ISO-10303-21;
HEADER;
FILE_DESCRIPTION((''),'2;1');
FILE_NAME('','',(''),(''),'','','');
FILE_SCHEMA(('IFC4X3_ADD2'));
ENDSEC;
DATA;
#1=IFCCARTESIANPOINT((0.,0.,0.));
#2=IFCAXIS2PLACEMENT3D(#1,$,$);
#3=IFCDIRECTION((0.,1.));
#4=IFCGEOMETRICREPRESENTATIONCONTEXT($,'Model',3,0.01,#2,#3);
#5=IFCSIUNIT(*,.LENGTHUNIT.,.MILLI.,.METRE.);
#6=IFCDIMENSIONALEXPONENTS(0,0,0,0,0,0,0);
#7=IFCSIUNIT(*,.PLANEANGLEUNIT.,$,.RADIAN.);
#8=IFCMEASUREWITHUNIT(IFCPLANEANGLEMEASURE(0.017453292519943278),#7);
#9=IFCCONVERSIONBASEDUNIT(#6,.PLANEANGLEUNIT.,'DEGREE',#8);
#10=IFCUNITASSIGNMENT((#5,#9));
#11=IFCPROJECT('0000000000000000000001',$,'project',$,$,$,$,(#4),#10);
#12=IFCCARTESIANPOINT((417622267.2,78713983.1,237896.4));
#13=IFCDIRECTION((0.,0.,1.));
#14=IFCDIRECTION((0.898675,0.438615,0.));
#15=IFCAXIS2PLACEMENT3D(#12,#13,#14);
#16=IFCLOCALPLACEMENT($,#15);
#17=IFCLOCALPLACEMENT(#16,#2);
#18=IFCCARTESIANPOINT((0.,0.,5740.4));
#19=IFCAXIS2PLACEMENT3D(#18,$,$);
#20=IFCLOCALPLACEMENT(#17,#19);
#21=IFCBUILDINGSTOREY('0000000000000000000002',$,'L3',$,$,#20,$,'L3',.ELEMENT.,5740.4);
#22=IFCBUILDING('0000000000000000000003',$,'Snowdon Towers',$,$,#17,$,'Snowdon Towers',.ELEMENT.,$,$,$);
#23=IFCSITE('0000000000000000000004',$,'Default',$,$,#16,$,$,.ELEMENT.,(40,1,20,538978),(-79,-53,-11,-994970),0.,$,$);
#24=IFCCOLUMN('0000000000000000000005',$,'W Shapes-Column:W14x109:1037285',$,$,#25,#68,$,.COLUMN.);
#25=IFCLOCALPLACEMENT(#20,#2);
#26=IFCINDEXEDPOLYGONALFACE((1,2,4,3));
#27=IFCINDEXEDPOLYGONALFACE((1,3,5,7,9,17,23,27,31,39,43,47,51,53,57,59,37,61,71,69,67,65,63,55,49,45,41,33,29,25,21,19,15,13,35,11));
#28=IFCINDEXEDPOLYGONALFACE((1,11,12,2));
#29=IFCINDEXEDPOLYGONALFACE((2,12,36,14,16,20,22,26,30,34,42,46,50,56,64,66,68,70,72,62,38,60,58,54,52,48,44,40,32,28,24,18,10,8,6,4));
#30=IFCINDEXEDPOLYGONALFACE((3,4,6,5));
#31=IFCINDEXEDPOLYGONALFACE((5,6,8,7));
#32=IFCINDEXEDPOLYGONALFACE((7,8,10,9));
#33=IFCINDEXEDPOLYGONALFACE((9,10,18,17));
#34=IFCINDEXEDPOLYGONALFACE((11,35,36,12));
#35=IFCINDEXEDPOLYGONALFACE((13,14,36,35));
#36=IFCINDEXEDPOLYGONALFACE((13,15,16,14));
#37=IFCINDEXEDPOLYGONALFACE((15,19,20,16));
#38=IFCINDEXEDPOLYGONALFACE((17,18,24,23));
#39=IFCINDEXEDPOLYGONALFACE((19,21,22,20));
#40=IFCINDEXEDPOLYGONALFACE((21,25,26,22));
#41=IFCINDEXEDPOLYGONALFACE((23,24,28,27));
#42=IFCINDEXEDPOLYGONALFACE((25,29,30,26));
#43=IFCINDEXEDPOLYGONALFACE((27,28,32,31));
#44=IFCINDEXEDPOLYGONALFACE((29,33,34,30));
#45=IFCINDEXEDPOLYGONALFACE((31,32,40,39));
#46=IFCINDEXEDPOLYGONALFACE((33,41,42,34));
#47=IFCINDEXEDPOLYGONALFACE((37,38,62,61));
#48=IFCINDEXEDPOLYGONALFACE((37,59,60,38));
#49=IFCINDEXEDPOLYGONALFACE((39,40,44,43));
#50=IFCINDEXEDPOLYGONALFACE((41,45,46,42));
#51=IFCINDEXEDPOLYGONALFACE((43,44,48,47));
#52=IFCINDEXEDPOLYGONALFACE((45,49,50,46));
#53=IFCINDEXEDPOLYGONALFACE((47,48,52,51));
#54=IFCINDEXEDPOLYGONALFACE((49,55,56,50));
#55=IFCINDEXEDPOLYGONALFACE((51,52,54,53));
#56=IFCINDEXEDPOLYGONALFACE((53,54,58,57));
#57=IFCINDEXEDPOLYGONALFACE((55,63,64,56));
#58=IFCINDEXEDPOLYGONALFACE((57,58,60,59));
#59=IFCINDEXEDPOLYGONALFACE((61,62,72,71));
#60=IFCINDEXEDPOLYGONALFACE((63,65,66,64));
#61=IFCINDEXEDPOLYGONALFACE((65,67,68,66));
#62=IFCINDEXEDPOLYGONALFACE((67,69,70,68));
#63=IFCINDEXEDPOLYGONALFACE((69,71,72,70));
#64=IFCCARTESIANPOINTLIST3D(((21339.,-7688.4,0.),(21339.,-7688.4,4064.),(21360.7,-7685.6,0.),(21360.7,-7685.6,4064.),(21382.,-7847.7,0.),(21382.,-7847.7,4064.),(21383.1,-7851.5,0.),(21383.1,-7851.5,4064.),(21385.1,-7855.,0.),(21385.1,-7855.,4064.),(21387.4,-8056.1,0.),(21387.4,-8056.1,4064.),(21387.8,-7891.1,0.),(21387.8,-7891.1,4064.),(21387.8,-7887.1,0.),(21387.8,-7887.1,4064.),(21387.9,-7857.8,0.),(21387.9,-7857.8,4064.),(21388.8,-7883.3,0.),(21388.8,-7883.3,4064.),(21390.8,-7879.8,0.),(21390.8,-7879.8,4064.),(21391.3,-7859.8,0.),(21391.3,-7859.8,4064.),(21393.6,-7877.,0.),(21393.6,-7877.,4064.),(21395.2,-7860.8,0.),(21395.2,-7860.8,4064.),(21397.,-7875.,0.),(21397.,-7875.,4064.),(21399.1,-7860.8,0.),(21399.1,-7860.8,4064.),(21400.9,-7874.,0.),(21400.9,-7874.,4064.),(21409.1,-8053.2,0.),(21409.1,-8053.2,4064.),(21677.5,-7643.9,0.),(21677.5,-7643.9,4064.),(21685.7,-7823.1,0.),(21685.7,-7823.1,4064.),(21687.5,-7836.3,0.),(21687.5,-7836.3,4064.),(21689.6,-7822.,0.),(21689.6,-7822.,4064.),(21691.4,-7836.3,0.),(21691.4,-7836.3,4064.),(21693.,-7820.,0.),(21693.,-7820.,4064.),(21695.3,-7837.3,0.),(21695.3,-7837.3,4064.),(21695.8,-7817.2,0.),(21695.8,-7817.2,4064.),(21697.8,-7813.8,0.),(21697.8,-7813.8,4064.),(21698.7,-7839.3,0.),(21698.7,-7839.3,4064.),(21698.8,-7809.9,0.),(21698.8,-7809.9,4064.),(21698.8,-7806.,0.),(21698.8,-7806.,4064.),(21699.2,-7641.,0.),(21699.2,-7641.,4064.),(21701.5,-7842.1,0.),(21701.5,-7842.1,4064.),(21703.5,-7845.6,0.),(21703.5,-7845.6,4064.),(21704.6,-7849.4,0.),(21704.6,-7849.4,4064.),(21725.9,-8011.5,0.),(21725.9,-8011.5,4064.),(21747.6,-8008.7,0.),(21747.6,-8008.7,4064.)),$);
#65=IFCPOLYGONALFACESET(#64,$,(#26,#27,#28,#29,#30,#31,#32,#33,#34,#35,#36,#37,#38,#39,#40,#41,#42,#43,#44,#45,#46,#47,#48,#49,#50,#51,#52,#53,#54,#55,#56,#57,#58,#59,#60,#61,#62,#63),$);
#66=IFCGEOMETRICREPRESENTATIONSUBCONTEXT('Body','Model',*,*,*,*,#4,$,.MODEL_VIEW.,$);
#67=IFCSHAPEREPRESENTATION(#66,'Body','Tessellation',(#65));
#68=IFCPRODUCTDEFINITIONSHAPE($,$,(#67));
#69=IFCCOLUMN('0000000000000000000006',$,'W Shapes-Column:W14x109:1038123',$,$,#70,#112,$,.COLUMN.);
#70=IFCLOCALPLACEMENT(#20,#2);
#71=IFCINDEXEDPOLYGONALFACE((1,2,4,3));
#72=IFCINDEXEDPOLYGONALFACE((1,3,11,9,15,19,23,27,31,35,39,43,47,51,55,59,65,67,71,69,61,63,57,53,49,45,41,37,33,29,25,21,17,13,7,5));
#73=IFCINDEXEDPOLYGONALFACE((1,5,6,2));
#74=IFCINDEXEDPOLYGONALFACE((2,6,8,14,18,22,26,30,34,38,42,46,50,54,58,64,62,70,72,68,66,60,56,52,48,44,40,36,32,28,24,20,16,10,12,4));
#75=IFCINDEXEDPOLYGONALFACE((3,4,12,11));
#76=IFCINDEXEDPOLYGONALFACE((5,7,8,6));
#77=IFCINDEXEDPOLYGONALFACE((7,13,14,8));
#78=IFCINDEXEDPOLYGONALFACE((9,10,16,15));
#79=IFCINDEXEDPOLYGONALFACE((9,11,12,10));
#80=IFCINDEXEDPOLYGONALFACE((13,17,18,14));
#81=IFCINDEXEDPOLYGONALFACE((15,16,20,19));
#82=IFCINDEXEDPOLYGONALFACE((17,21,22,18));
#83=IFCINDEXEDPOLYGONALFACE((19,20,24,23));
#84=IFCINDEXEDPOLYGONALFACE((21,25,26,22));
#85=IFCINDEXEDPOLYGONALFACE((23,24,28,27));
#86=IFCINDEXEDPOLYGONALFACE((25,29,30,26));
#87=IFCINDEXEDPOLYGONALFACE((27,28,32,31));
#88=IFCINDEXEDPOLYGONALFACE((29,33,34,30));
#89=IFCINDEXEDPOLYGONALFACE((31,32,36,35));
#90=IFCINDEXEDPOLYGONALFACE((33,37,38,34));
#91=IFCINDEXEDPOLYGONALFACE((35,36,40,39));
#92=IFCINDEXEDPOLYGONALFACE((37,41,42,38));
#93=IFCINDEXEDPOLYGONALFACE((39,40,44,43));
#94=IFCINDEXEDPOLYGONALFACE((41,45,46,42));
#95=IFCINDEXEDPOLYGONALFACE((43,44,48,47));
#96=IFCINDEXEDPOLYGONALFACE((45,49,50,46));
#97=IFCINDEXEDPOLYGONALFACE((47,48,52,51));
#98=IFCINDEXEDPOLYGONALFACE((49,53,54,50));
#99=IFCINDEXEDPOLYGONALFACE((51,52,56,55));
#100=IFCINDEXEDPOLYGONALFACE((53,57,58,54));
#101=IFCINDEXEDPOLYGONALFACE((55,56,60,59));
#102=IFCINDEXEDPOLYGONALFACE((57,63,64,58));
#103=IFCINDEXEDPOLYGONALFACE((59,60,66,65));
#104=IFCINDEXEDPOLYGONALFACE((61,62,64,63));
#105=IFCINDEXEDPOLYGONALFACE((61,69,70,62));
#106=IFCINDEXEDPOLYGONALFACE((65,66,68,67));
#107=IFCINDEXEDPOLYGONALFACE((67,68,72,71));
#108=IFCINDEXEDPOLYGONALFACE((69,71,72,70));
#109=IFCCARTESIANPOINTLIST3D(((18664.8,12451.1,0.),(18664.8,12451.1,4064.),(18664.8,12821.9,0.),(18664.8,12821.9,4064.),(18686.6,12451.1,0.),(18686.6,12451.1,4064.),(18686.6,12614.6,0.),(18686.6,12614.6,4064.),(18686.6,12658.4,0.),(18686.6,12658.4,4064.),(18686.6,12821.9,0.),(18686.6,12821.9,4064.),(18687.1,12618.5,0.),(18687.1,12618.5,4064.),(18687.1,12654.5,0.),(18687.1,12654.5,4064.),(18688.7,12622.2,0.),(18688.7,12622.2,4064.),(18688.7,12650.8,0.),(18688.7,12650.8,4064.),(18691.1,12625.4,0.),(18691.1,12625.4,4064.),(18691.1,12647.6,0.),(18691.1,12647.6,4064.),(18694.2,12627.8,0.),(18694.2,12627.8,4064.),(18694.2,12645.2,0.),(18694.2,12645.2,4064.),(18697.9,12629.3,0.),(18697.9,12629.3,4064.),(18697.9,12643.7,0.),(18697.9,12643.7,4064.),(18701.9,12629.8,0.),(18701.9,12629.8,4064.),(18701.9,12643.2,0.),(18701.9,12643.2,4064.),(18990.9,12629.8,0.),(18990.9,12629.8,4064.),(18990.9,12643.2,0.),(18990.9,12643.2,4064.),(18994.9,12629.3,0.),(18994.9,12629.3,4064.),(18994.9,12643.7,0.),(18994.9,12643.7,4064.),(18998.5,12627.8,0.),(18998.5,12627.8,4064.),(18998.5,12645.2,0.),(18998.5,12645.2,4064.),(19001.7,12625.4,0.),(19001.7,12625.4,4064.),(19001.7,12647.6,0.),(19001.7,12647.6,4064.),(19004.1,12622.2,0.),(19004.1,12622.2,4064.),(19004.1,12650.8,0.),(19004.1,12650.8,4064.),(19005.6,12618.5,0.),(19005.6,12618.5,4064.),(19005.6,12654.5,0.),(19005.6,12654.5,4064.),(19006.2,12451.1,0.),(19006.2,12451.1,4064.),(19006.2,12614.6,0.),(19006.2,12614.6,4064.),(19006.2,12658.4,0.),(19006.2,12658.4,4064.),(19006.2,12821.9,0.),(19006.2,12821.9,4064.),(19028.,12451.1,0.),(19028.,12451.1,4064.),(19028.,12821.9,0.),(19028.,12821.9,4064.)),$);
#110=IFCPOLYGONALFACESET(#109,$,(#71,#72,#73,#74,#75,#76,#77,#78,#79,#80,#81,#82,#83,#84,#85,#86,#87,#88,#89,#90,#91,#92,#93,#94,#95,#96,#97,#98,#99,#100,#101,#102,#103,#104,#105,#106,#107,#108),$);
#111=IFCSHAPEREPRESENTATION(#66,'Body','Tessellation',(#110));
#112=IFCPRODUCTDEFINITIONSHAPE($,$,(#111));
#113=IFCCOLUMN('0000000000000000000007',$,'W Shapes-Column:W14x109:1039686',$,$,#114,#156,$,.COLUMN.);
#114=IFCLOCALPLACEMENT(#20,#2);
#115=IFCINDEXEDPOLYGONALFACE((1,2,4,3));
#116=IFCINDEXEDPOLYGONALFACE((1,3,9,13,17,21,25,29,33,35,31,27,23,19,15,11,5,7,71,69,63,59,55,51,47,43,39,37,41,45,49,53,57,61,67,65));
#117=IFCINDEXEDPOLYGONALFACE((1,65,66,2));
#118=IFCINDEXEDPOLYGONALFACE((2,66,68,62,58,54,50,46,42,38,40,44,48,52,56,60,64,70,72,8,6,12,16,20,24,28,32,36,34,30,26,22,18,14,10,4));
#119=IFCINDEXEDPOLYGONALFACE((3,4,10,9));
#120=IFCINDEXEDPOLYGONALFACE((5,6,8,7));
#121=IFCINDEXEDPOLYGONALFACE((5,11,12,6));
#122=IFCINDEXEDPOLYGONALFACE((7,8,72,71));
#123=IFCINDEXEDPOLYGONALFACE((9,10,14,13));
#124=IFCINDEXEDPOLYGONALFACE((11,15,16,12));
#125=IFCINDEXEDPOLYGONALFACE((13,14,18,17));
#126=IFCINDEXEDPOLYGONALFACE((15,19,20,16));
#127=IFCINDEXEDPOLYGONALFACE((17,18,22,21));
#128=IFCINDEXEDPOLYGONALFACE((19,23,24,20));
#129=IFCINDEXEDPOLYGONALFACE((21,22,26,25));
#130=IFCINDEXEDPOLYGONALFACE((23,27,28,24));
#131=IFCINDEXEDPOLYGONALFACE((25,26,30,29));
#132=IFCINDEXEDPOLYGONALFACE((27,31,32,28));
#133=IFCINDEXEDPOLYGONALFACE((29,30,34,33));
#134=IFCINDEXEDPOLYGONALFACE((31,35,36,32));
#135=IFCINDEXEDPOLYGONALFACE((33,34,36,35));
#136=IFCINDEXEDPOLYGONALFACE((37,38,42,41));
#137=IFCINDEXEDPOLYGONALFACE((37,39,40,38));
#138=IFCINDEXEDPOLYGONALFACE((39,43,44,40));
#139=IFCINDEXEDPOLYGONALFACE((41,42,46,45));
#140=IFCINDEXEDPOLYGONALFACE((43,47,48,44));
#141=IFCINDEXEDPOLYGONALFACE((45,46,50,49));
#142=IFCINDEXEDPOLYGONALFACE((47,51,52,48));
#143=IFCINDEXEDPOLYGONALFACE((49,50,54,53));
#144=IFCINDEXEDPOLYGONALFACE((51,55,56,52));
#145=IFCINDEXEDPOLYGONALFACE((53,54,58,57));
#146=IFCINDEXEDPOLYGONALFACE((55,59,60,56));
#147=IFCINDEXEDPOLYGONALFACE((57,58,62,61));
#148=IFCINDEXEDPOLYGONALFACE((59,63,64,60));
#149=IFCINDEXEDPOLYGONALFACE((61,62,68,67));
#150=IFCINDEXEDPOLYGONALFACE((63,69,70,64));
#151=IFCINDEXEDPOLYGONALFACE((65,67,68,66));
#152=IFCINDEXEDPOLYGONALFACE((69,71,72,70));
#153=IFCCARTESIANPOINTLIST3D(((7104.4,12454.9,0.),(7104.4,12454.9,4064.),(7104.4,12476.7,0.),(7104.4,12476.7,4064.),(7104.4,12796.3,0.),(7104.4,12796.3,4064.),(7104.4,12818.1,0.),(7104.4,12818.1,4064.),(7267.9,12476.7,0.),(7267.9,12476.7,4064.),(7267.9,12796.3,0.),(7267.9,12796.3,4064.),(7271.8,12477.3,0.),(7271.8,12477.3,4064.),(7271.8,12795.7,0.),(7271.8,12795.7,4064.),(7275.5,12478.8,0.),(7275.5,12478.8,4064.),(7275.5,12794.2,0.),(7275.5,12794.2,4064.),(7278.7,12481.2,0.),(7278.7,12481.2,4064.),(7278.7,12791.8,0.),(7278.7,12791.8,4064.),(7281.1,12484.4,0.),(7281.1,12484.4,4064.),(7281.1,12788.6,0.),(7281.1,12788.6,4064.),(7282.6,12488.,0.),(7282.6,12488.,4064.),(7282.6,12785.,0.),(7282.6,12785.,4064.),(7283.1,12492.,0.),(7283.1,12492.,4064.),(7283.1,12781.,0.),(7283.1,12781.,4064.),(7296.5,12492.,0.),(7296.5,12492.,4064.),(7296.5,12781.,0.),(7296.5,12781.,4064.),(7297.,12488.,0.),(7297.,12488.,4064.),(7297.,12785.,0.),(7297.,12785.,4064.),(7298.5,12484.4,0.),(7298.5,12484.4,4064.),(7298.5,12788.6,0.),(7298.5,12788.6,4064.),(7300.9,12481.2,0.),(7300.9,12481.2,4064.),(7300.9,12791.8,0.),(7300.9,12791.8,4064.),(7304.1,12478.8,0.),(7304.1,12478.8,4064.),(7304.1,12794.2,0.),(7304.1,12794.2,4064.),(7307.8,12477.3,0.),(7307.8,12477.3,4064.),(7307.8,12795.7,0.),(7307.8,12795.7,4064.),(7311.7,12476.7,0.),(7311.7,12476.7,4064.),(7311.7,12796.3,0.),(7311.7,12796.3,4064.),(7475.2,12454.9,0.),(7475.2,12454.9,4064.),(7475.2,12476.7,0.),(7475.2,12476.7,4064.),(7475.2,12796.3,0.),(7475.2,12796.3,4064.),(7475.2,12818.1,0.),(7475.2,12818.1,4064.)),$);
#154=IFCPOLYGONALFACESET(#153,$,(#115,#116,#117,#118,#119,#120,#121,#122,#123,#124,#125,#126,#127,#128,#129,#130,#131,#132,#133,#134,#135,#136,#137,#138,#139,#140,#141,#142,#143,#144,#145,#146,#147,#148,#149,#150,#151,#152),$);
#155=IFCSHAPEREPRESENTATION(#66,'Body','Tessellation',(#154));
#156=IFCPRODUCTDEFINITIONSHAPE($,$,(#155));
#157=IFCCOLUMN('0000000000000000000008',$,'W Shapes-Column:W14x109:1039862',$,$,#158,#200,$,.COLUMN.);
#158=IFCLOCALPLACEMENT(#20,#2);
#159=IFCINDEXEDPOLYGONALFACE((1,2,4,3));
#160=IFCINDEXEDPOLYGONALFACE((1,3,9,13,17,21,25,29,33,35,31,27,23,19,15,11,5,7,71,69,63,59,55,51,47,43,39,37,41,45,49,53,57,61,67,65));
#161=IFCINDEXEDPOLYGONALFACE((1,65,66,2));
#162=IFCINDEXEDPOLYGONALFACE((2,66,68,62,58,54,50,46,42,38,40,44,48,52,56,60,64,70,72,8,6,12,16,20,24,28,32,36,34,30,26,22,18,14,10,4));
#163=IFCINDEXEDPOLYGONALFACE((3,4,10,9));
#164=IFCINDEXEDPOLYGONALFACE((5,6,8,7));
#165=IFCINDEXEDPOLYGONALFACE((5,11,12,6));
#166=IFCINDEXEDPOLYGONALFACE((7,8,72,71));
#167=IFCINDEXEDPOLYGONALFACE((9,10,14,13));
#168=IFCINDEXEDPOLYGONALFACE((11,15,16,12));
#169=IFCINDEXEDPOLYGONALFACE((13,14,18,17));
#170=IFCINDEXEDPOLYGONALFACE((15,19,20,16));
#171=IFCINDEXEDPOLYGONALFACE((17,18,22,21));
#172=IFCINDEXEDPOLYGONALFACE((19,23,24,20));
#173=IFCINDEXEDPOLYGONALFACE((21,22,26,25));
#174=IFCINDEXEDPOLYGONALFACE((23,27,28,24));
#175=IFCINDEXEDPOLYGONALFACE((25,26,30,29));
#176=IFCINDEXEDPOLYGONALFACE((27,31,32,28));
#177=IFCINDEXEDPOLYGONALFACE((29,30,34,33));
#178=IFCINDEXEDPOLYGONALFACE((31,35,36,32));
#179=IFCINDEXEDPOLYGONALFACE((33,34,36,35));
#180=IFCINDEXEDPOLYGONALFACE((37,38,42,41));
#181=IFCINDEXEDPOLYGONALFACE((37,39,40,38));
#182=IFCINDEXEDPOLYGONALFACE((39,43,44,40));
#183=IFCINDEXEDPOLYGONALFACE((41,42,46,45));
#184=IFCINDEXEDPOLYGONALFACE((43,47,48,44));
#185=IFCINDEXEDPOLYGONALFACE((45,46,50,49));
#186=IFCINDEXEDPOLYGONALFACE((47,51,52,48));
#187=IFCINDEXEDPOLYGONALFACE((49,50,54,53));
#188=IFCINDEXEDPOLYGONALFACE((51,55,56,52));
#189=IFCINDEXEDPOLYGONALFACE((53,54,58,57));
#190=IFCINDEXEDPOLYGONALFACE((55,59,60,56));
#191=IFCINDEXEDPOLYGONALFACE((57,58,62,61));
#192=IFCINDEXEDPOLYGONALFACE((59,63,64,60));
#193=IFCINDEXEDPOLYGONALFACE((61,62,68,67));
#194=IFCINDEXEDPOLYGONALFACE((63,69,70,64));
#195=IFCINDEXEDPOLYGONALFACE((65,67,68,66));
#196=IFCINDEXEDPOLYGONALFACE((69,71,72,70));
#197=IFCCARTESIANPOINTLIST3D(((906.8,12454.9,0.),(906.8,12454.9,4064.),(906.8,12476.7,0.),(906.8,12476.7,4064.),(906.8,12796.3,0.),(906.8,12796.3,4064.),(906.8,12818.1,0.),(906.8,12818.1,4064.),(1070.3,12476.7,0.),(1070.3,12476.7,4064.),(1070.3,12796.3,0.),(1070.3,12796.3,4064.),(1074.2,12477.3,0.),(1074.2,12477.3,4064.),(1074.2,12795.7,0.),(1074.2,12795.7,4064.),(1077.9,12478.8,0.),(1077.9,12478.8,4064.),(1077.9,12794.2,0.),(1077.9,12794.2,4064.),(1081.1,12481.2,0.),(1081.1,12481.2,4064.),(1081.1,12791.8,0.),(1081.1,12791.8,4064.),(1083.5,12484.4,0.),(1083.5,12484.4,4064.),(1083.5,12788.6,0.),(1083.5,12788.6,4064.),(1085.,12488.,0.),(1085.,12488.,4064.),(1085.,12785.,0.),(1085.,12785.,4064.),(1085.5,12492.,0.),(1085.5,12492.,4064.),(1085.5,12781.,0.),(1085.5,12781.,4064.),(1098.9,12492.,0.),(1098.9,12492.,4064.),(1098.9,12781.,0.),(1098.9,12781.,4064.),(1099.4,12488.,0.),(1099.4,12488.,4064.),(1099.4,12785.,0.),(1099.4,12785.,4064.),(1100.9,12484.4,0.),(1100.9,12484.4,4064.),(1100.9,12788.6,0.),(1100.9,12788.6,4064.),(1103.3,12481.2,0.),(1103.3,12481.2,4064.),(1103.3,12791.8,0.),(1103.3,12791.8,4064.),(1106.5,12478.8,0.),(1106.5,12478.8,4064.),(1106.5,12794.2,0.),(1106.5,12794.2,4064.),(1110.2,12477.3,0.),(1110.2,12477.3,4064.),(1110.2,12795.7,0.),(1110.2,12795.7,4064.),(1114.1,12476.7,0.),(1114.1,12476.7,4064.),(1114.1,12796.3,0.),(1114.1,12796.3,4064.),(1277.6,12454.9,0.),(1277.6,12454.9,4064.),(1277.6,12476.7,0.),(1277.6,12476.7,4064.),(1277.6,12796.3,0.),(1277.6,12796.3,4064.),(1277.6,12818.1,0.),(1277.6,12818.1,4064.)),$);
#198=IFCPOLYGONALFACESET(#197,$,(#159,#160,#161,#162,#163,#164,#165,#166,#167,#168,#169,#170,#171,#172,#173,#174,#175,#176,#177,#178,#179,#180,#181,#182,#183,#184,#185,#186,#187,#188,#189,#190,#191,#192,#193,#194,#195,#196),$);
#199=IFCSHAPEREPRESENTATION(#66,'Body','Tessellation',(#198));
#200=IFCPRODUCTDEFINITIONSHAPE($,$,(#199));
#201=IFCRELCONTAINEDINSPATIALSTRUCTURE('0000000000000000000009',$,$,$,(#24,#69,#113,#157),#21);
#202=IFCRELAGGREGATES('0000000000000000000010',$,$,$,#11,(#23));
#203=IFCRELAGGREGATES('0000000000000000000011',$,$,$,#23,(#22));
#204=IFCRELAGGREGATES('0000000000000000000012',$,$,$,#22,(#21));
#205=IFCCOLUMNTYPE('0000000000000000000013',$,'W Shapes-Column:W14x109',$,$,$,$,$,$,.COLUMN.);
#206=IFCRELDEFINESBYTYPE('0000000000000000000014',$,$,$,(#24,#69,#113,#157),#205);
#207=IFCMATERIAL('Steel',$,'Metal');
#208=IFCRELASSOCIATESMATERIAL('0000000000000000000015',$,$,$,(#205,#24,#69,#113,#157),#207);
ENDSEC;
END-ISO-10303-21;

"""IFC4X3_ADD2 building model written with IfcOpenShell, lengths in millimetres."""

from ifc_helpers import new_model, entity, si_unit, converted_unit, direction, frame, frame_2d, origin, place, context, subcontext, project, spatial, i_section, extrude, source, transform, mapped, material, material_profile, profile_set, profile_usage, type_object, type_shapes, element, save


model = new_model("IFC4X3_ADD2")

# Units and contexts
model_context = context("Model", 3, precision=0.01, world=origin(), true_north=direction((0.0, 1.0)))
body_context = subcontext(model_context, "Body", "Model", "MODEL_VIEW")
ifc_project = project(units=[si_unit("LENGTHUNIT", "METRE", prefix="MILLI"), converted_unit("PLANEANGLEUNIT", "DEGREE", entity("IfcPlaneAngleMeasure", 0.017453292519943278), si_unit("PLANEANGLEUNIT", "RADIAN"), dimensions=[0, 0, 0, 0, 0, 0, 0])], contexts=[model_context])

# Site, building, storey
site_placement = place(None, frame((417622267.2, 78713983.1, 237896.4), z_axis=(0.0, 0.0, 1.0), x_axis=(0.898675, 0.438615, 0.0)))
site = spatial("IfcSite", under=ifc_project, at=site_placement, Name="Default", CompositionType="ELEMENT", RefLatitude=(40, 1, 20, 538978), RefLongitude=(-79, -53, -11, -994970), RefElevation=0.0)
building_placement = place(site_placement, origin())
building = spatial("IfcBuilding", under=site, at=building_placement, Name="Snowdon Towers", LongName="Snowdon Towers", CompositionType="ELEMENT")
storey_placement = place(building_placement, frame((0.0, 0.0, 5740.4)))
storey = spatial("IfcBuildingStorey", under=building, at=storey_placement, Name="L3", LongName="L3", CompositionType="ELEMENT", Elevation=5740.4)

# Columns
ifc_material_1 = material(Name="Steel", Category="Metal")
ifc_material_profile_1 = material_profile(ifc_material_1, i_section(OverallWidth=370.8, OverallDepth=363.2, WebThickness=13.3, FlangeThickness=21.8, FilletRadius=15.2, at=frame_2d((0.0, 0.0), x_axis=(1.0, 0.0))), Name="W14x109")
ifc_profile_set_1 = profile_set([ifc_material_profile_1], Name="W14x109")
ifc_profile_usage_1 = profile_usage(ifc_profile_set_1)
column_type_1 = type_object("IfcColumnType", Name="W Shapes-Column:W14x109", PredefinedType="COLUMN", material=ifc_profile_set_1)
shared_shape_1 = source(origin(), body_context, "Body", "SweptSolid", [
    extrude(i_section(OverallWidth=370.8, OverallDepth=363.2, WebThickness=13.3, FlangeThickness=21.8, FilletRadius=15.2, at=frame_2d((0.0, 0.0), x_axis=(1.0, 0.0))), frame((0.0, 0.0, 5740.4), z_axis=(0.0, 0.0, 1.0), x_axis=(-1.0, 0.0, 0.0)), (0.0, 0.0, 1.0), 4064.0),
])
type_shapes(column_type_1, [shared_shape_1])
for number, where, z_axis, x_axis, name in (
    (1, (21543.3, -7848.5, -5740.4), (0.0, 0.0, 1.0), (-0.130526, 0.991445, 0.0), "W Shapes-Column:W14x109:1037285"),
    (2, (18846.4, 12636.5, -5740.4), (0.0, 0.0, 1.0), (0.0, 1.0, 0.0), "W Shapes-Column:W14x109:1038123"),
):
    element("IfcColumn", number, at=place(storey_placement, frame(where, z_axis=z_axis, x_axis=x_axis)), inside=storey, type_object=column_type_1, material=ifc_profile_usage_1, Name=name, PredefinedType="COLUMN", context=body_context, shape_type="MappedRepresentation", body=[
        mapped(shared_shape_1, transform((0.0, 0.0, 0.0), scale=1.0)),
    ])
column_1_placement = place(storey_placement, frame((7289.8, 12636.5, -5740.4)))
element("IfcColumn", 3, at=column_1_placement, inside=storey, type_object=column_type_1, material=ifc_profile_usage_1, Name="W Shapes-Column:W14x109:1039686", PredefinedType="COLUMN", context=body_context, shape_type="MappedRepresentation", body=[
    mapped(shared_shape_1, transform((0.0, 0.0, 0.0), scale=1.0)),
])
column_2_placement = place(storey_placement, frame((1092.2, 12636.5, -5740.4), z_axis=(0.0, 0.0, 1.0), x_axis=(-1.0, 0.0, 0.0)))
element("IfcColumn", 4, at=column_2_placement, inside=storey, type_object=column_type_1, material=ifc_profile_usage_1, Name="W Shapes-Column:W14x109:1039862", PredefinedType="COLUMN", context=body_context, shape_type="MappedRepresentation", body=[
    mapped(shared_shape_1, transform((0.0, 0.0, 0.0), scale=1.0)),
])

save(model, "model.ifc")
